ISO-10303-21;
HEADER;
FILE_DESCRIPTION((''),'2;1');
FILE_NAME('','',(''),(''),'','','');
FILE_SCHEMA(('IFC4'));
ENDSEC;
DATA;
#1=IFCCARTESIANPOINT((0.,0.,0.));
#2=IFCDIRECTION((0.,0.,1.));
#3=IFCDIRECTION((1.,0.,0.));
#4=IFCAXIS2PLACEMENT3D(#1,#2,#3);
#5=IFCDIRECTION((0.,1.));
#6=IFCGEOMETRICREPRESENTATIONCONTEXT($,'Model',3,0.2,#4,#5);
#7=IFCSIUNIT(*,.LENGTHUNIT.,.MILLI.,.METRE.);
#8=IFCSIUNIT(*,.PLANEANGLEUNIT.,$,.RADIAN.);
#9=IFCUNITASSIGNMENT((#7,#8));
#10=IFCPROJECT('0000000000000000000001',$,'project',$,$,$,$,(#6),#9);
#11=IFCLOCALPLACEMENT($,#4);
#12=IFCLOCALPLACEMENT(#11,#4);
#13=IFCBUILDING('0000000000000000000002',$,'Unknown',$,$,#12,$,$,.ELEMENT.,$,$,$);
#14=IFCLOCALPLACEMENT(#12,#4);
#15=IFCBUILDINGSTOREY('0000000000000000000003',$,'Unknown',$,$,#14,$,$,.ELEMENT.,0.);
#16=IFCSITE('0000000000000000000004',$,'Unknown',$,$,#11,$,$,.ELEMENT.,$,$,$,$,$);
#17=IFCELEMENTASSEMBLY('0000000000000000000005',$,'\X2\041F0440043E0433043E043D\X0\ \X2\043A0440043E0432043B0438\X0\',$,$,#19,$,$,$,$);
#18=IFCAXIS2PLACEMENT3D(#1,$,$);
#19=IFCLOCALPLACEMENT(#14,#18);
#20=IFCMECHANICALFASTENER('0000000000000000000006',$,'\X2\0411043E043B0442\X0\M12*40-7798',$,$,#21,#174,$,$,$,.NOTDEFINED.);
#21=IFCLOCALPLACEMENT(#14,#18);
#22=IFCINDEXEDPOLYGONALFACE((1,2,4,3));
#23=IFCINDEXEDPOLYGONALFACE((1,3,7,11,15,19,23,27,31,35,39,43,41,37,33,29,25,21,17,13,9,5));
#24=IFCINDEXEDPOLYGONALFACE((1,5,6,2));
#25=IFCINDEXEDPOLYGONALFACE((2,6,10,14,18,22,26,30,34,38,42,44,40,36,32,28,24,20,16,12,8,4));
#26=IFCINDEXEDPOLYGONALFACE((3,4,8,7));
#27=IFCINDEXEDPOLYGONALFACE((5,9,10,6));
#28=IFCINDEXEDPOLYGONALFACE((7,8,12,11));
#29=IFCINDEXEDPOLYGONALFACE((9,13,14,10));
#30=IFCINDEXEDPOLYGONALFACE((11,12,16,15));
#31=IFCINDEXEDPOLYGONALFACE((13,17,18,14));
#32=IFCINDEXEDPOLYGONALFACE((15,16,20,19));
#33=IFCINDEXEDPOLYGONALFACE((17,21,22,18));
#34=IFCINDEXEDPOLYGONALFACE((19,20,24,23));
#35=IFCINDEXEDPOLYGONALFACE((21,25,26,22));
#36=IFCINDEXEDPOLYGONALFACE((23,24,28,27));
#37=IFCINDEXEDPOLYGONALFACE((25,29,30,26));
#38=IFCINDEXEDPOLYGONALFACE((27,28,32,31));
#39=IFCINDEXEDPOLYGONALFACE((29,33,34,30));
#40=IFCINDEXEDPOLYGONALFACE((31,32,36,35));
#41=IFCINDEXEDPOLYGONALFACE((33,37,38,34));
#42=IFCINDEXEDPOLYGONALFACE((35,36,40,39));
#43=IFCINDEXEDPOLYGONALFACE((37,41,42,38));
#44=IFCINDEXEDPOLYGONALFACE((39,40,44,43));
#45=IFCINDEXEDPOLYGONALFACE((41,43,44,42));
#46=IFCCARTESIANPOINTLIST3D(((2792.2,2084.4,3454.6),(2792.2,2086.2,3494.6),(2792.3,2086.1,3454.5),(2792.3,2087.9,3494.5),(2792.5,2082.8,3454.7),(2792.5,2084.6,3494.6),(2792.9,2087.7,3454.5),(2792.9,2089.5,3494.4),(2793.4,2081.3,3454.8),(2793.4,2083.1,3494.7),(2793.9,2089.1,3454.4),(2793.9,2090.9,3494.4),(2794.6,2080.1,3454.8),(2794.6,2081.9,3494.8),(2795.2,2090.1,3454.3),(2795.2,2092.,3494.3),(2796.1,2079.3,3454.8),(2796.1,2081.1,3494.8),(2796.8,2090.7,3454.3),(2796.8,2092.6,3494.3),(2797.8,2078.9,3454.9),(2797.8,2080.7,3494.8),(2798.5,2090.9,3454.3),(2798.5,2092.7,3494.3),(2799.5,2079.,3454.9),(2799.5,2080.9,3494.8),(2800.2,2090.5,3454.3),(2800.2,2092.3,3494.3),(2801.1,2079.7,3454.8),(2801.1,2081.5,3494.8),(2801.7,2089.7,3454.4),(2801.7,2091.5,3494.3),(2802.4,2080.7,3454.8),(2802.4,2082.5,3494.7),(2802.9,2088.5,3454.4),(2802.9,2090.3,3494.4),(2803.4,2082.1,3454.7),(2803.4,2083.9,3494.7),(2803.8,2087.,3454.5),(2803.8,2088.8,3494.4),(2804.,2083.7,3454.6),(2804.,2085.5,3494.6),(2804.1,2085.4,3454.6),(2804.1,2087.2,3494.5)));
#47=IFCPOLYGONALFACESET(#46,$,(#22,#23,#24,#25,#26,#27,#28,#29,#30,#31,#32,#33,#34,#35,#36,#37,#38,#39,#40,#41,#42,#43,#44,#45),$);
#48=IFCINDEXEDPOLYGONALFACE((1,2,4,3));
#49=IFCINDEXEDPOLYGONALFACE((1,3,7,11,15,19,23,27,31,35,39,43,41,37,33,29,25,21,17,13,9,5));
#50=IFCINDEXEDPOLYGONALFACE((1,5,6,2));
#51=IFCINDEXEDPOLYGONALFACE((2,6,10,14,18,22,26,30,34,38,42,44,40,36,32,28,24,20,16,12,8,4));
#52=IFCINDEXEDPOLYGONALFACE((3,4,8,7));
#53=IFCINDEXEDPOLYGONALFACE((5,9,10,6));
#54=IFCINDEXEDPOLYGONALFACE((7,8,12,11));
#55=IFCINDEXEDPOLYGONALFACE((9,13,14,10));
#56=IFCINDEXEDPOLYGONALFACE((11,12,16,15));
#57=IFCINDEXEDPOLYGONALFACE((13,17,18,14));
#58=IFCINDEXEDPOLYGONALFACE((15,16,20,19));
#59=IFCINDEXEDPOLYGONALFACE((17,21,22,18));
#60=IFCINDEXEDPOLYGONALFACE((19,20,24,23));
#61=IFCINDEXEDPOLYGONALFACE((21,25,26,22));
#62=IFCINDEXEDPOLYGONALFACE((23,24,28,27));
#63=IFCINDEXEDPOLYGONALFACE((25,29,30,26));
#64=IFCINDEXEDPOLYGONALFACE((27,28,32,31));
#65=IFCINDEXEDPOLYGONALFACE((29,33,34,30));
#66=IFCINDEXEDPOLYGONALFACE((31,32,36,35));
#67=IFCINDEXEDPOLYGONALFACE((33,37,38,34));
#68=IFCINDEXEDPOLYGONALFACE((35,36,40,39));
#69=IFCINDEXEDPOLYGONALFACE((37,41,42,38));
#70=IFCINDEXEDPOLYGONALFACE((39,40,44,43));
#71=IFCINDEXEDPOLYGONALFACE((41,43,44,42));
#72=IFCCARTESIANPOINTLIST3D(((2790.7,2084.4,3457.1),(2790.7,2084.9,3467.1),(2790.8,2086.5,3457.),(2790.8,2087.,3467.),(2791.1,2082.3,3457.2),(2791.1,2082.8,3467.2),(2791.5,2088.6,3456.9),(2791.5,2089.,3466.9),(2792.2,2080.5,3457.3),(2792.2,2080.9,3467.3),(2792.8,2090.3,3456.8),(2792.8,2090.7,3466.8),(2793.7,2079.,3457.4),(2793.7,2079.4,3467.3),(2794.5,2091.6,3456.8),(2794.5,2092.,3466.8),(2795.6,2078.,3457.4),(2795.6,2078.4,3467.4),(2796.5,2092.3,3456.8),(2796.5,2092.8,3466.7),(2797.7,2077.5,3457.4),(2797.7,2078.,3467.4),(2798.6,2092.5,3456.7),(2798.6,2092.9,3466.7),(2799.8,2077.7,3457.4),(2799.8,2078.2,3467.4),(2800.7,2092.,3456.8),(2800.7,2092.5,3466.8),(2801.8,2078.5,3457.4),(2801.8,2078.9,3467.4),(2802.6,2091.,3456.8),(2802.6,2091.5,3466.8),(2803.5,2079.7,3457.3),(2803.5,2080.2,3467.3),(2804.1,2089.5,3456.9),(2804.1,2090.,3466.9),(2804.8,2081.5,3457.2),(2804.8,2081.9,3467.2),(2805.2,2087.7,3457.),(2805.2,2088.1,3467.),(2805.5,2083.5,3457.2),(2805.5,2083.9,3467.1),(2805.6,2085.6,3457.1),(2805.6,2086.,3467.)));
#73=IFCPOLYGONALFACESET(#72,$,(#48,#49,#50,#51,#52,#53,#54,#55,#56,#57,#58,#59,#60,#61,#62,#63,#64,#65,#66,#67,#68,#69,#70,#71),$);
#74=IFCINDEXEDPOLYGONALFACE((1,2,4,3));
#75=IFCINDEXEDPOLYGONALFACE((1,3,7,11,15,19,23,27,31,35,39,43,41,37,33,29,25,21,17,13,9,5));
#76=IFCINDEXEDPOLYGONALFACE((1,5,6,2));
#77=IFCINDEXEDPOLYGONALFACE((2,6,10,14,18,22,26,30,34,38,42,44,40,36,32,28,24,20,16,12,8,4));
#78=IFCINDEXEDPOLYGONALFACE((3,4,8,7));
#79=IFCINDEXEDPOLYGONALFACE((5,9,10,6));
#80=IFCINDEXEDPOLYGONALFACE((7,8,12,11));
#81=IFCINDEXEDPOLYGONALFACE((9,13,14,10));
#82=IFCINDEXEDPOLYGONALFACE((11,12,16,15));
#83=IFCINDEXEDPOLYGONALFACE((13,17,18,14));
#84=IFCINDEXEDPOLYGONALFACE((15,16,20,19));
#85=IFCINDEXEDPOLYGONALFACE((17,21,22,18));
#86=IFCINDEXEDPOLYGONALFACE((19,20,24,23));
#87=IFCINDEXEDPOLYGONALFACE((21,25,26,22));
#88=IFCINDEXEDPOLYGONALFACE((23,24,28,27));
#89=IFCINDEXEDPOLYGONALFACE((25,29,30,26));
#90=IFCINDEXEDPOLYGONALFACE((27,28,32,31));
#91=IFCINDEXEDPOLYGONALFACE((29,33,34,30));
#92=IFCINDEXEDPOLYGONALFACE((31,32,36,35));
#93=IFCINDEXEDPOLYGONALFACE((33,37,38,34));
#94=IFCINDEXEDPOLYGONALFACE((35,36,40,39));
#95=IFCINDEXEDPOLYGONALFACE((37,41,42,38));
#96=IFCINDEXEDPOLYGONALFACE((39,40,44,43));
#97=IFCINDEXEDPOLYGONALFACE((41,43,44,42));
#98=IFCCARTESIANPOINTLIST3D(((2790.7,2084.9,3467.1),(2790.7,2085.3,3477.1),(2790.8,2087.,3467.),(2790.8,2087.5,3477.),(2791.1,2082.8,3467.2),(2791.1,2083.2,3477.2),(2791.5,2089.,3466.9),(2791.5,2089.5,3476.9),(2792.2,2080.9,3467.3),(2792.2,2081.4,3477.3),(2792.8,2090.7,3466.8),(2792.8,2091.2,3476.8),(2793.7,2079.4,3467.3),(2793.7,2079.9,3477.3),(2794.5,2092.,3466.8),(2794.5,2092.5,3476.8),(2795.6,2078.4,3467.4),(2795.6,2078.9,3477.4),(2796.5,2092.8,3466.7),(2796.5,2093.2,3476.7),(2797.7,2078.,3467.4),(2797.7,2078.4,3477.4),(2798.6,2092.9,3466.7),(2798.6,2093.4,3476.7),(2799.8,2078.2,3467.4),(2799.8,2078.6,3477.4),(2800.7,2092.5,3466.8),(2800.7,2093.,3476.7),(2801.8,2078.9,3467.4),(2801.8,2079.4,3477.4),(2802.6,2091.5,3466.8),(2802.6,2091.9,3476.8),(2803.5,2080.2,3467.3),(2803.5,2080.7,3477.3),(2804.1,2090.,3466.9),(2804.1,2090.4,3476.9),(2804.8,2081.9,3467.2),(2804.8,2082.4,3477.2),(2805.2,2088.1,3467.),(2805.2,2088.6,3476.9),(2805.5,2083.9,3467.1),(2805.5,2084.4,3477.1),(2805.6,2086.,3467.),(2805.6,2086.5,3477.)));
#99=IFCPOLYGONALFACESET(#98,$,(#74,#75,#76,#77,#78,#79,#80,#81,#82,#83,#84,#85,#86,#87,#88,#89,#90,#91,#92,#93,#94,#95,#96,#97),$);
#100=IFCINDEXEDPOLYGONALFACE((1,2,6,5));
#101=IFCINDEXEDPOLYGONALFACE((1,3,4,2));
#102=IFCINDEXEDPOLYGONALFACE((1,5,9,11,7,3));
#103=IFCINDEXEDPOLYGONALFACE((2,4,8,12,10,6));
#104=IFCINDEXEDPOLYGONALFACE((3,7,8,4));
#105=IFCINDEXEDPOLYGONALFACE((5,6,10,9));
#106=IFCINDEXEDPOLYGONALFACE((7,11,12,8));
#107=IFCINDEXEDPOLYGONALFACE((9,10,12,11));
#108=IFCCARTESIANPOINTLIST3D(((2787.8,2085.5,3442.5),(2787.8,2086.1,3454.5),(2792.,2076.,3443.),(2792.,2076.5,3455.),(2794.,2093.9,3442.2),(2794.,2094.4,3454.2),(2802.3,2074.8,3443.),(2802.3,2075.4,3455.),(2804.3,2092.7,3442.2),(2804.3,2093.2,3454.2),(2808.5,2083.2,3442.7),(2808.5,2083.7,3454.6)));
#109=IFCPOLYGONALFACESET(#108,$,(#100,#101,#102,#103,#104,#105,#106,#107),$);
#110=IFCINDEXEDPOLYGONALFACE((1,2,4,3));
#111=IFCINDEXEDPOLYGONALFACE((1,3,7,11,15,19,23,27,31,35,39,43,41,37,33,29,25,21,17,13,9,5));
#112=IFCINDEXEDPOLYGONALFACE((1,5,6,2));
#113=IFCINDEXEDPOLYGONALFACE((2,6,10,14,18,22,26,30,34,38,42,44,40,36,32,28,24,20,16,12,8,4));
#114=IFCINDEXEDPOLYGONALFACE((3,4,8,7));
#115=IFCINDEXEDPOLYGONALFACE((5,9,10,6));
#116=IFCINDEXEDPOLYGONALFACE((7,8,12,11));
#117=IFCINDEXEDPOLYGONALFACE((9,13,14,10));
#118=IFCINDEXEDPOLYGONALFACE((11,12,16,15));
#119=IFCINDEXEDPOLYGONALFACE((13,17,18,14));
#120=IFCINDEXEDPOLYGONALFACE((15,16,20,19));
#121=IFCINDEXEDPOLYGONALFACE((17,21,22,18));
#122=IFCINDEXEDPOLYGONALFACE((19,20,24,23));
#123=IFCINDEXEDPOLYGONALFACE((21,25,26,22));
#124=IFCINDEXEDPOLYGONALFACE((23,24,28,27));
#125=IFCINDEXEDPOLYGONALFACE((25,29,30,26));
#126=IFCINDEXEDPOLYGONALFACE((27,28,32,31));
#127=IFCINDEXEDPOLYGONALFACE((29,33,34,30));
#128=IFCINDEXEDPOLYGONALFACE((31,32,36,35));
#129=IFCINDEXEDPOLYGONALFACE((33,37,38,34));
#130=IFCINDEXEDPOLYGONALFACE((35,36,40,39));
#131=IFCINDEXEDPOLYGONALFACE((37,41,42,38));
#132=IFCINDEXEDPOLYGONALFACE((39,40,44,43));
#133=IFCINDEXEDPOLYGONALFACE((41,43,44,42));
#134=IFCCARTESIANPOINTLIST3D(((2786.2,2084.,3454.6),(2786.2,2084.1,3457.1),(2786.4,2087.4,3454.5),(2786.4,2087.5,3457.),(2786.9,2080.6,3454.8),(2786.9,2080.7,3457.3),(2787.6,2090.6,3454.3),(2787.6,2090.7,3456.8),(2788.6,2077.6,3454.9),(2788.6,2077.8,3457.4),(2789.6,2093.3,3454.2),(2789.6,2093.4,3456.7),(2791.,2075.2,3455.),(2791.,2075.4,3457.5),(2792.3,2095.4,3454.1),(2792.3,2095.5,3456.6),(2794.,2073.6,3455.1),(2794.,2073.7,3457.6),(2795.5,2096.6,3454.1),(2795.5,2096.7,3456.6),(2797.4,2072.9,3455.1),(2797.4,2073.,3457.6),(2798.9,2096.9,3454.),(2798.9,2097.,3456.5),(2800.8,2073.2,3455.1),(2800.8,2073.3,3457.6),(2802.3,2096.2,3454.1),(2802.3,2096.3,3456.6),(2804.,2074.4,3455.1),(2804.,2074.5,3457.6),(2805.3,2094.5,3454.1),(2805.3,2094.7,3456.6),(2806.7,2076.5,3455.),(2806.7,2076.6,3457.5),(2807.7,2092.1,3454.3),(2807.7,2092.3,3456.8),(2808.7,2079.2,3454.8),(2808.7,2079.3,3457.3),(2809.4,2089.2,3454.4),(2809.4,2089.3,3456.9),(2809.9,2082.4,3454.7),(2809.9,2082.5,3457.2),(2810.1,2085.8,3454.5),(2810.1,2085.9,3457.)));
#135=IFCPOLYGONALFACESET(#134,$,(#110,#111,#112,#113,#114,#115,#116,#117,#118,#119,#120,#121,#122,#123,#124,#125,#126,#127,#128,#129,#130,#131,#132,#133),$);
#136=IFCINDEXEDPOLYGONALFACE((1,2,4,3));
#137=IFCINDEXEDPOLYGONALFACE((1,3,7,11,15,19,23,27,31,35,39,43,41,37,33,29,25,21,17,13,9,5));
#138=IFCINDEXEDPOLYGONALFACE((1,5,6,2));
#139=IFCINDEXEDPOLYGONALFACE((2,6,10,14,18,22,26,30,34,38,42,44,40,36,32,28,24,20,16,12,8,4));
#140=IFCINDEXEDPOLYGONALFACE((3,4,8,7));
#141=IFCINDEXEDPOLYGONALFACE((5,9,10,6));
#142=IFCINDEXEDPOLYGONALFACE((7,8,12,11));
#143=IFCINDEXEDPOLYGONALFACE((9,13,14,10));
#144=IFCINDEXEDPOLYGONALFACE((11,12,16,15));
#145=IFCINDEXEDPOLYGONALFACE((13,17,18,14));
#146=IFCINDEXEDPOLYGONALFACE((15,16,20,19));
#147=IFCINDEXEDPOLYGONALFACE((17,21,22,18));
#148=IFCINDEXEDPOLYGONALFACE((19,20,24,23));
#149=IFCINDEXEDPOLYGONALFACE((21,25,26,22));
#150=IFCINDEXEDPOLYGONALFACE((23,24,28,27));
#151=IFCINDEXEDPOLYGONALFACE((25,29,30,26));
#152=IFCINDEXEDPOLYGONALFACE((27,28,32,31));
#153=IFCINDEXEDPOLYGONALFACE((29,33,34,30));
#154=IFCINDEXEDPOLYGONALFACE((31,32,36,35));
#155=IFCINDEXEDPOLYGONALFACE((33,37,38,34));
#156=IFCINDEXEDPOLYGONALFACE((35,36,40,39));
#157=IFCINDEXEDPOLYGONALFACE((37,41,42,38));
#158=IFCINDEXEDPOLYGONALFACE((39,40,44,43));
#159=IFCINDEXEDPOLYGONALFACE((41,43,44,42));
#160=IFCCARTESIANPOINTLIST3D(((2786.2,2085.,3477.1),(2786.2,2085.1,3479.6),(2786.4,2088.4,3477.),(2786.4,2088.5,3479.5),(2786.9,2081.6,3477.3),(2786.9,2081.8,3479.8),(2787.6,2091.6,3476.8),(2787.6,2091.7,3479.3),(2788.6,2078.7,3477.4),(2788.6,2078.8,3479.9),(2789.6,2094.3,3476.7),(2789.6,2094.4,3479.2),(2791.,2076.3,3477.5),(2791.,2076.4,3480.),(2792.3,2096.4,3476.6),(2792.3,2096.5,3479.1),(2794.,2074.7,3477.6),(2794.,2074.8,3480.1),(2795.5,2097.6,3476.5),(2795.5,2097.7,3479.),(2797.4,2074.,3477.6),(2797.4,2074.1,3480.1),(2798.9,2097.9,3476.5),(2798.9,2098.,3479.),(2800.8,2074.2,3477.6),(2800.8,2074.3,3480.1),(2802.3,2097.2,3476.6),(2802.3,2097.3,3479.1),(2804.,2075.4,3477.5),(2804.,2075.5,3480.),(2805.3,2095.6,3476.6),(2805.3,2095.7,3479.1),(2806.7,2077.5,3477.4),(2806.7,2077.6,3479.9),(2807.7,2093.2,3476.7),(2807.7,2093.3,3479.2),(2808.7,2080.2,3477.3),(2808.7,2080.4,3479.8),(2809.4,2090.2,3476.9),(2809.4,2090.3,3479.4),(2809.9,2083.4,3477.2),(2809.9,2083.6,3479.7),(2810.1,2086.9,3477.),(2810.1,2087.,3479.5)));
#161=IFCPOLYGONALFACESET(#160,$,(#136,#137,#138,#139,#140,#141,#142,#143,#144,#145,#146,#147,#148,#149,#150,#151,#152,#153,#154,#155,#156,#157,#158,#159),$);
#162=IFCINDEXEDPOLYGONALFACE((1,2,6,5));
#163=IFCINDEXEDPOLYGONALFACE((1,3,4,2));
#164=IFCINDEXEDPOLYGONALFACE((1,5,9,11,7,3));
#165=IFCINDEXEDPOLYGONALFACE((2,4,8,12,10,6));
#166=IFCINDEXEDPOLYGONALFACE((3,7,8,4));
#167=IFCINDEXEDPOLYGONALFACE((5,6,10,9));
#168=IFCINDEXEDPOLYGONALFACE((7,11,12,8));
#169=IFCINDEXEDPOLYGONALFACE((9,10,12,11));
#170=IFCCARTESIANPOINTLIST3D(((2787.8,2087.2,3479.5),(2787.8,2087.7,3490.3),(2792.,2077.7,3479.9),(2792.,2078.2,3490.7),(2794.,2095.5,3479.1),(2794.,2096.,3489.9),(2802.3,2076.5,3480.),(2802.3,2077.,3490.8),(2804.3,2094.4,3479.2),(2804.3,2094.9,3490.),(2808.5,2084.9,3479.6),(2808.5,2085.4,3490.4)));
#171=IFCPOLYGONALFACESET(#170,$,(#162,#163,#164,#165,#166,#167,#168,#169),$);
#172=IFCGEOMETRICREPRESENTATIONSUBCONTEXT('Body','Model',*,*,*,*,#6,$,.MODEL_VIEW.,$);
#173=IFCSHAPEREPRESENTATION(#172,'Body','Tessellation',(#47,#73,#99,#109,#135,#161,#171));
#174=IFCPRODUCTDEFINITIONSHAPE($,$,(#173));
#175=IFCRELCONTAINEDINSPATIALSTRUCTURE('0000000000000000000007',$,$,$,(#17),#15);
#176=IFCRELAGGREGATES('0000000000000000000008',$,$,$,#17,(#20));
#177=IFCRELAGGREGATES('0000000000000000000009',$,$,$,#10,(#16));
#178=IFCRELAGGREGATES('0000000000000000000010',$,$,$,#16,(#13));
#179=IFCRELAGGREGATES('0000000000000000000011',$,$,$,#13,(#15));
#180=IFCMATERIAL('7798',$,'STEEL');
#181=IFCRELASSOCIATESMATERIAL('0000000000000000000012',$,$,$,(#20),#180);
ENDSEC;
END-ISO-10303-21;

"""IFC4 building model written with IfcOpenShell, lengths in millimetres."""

from ifc_helpers import new_model, si_unit, direction, frame, origin_with_axes, place, context, subcontext, project, spatial, line, arc, indexed_curve, outline, extrude, source, transform, mapped, material, element, aggregate, save


model = new_model("IFC4")

# Units and contexts
model_context = context("Model", 3, precision=0.2, world=origin_with_axes(), true_north=direction((0.0, 1.0)))
body_context = subcontext(model_context, "Body", "Model", "MODEL_VIEW")
ifc_project = project(units=[si_unit("LENGTHUNIT", "METRE", prefix="MILLI"), si_unit("PLANEANGLEUNIT", "RADIAN")], contexts=[model_context])

# Site, building, storey
site_placement = place(None, origin_with_axes())
site = spatial("IfcSite", under=ifc_project, at=site_placement, Name="Unknown", CompositionType="ELEMENT")
building_placement = place(site_placement, origin_with_axes())
building = spatial("IfcBuilding", under=site, at=building_placement, Name="Unknown", CompositionType="ELEMENT")
storey_placement = place(building_placement, origin_with_axes())
storey = spatial("IfcBuildingStorey", under=building, at=storey_placement, Name="Unknown", CompositionType="ELEMENT", Elevation=0.0)

# Element assembly
assembly_1_placement = place(storey_placement, frame((-595.0, 2187.1, 3457.5), z_axis=(0.0, -0.998969, 0.045408), x_axis=(1.0, 0.0, 0.0)))
assembly_1 = element("IfcElementAssembly", 1, at=assembly_1_placement, inside=storey, Name="Прогон кровли")

# Mechanical fastener
ifc_material_1 = material(Name="7798", Category="STEEL")
shared_shape_1 = source(origin_with_axes(), body_context, "Body", "SweptSolid", [
    extrude(outline(indexed_curve([(6.0, 0.0), (0.0, 6.0), (-6.0, 0.0), (0.0, -6.0)], segments=[arc(1, 2, 3), arc(3, 4, 1)])), frame((0.0, 0.0, 2.5), z_axis=(0.0, 0.0, -1.0), x_axis=(0.0, 1.0, 0.0)), (0.0, 0.0, 1.0), 40.0),
    extrude(outline(indexed_curve([(7.5, 0.0), (0.0, 7.5), (-7.5, 0.0), (0.0, -7.5)], segments=[arc(1, 2, 3), arc(3, 4, 1)])), frame((0.0, 0.0, 0.0), z_axis=(0.0, 0.0, -1.0), x_axis=(0.0, 1.0, 0.0)), (0.0, 0.0, 1.0), 10.0),
    extrude(outline(indexed_curve([(7.5, 0.0), (0.0, 7.5), (-7.5, 0.0), (0.0, -7.5)], segments=[arc(1, 2, 3), arc(3, 4, 1)])), frame((0.0, 0.0, -10.0), z_axis=(0.0, 0.0, -1.0), x_axis=(0.0, 1.0, 0.0)), (0.0, 0.0, 1.0), 10.0),
    extrude(outline(indexed_curve([(10.4, 0.0), (5.2, 9.0), (-5.2, 9.0), (-10.4, 0.0), (-5.2, -9.0), (5.2, -9.0)], segments=[line(1, 2, 3, 4, 5, 6, 1)])), frame((0.0, 0.0, 14.5), z_axis=(0.0, 0.0, -1.0), x_axis=(0.0, 1.0, 0.0)), (0.0, 0.0, 1.0), 12.0),
    extrude(outline(indexed_curve([(12.0, 0.0), (0.0, 12.0), (-12.0, 0.0), (0.0, -12.0)], segments=[arc(1, 2, 3), arc(3, 4, 1)])), frame((0.0, 0.0, 2.5), z_axis=(0.0, 0.0, -1.0), x_axis=(0.0, 1.0, 0.0)), (0.0, 0.0, 1.0), 2.5),
    extrude(outline(indexed_curve([(12.0, 0.0), (0.0, 12.0), (-12.0, 0.0), (0.0, -12.0)], segments=[arc(1, 2, 3), arc(3, 4, 1)])), frame((0.0, 0.0, -20.0), z_axis=(0.0, 0.0, -1.0), x_axis=(0.0, 1.0, 0.0)), (0.0, 0.0, 1.0), 2.5),
    extrude(outline(indexed_curve([(10.4, 0.0), (5.2, 9.0), (-5.2, 9.0), (-10.4, 0.0), (-5.2, -9.0), (5.2, -9.0)], segments=[line(1, 2, 3, 4, 5, 6, 1)])), frame((0.0, 0.0, -22.5), z_axis=(0.0, 0.0, -1.0), x_axis=(0.0, 1.0, 0.0)), (0.0, 0.0, 1.0), 10.8),
])
mechanical_fastener_1_placement = place(assembly_1_placement, frame((3393.1, -5.0, 102.0), z_axis=(0.0, -1.0, 0.0), x_axis=(0.804616, 0.0, 0.593795)))
mechanical_fastener_1 = element("IfcMechanicalFastener", 2, at=mechanical_fastener_1_placement, material=ifc_material_1, Name="БолтM12*40-7798", PredefinedType="NOTDEFINED", context=body_context, shape_type="MappedRepresentation", body=[
    mapped(shared_shape_1, transform((0.0, 0.0, 0.0))),
])
aggregate(assembly_1, [mechanical_fastener_1])

save(model, "model.ifc")
